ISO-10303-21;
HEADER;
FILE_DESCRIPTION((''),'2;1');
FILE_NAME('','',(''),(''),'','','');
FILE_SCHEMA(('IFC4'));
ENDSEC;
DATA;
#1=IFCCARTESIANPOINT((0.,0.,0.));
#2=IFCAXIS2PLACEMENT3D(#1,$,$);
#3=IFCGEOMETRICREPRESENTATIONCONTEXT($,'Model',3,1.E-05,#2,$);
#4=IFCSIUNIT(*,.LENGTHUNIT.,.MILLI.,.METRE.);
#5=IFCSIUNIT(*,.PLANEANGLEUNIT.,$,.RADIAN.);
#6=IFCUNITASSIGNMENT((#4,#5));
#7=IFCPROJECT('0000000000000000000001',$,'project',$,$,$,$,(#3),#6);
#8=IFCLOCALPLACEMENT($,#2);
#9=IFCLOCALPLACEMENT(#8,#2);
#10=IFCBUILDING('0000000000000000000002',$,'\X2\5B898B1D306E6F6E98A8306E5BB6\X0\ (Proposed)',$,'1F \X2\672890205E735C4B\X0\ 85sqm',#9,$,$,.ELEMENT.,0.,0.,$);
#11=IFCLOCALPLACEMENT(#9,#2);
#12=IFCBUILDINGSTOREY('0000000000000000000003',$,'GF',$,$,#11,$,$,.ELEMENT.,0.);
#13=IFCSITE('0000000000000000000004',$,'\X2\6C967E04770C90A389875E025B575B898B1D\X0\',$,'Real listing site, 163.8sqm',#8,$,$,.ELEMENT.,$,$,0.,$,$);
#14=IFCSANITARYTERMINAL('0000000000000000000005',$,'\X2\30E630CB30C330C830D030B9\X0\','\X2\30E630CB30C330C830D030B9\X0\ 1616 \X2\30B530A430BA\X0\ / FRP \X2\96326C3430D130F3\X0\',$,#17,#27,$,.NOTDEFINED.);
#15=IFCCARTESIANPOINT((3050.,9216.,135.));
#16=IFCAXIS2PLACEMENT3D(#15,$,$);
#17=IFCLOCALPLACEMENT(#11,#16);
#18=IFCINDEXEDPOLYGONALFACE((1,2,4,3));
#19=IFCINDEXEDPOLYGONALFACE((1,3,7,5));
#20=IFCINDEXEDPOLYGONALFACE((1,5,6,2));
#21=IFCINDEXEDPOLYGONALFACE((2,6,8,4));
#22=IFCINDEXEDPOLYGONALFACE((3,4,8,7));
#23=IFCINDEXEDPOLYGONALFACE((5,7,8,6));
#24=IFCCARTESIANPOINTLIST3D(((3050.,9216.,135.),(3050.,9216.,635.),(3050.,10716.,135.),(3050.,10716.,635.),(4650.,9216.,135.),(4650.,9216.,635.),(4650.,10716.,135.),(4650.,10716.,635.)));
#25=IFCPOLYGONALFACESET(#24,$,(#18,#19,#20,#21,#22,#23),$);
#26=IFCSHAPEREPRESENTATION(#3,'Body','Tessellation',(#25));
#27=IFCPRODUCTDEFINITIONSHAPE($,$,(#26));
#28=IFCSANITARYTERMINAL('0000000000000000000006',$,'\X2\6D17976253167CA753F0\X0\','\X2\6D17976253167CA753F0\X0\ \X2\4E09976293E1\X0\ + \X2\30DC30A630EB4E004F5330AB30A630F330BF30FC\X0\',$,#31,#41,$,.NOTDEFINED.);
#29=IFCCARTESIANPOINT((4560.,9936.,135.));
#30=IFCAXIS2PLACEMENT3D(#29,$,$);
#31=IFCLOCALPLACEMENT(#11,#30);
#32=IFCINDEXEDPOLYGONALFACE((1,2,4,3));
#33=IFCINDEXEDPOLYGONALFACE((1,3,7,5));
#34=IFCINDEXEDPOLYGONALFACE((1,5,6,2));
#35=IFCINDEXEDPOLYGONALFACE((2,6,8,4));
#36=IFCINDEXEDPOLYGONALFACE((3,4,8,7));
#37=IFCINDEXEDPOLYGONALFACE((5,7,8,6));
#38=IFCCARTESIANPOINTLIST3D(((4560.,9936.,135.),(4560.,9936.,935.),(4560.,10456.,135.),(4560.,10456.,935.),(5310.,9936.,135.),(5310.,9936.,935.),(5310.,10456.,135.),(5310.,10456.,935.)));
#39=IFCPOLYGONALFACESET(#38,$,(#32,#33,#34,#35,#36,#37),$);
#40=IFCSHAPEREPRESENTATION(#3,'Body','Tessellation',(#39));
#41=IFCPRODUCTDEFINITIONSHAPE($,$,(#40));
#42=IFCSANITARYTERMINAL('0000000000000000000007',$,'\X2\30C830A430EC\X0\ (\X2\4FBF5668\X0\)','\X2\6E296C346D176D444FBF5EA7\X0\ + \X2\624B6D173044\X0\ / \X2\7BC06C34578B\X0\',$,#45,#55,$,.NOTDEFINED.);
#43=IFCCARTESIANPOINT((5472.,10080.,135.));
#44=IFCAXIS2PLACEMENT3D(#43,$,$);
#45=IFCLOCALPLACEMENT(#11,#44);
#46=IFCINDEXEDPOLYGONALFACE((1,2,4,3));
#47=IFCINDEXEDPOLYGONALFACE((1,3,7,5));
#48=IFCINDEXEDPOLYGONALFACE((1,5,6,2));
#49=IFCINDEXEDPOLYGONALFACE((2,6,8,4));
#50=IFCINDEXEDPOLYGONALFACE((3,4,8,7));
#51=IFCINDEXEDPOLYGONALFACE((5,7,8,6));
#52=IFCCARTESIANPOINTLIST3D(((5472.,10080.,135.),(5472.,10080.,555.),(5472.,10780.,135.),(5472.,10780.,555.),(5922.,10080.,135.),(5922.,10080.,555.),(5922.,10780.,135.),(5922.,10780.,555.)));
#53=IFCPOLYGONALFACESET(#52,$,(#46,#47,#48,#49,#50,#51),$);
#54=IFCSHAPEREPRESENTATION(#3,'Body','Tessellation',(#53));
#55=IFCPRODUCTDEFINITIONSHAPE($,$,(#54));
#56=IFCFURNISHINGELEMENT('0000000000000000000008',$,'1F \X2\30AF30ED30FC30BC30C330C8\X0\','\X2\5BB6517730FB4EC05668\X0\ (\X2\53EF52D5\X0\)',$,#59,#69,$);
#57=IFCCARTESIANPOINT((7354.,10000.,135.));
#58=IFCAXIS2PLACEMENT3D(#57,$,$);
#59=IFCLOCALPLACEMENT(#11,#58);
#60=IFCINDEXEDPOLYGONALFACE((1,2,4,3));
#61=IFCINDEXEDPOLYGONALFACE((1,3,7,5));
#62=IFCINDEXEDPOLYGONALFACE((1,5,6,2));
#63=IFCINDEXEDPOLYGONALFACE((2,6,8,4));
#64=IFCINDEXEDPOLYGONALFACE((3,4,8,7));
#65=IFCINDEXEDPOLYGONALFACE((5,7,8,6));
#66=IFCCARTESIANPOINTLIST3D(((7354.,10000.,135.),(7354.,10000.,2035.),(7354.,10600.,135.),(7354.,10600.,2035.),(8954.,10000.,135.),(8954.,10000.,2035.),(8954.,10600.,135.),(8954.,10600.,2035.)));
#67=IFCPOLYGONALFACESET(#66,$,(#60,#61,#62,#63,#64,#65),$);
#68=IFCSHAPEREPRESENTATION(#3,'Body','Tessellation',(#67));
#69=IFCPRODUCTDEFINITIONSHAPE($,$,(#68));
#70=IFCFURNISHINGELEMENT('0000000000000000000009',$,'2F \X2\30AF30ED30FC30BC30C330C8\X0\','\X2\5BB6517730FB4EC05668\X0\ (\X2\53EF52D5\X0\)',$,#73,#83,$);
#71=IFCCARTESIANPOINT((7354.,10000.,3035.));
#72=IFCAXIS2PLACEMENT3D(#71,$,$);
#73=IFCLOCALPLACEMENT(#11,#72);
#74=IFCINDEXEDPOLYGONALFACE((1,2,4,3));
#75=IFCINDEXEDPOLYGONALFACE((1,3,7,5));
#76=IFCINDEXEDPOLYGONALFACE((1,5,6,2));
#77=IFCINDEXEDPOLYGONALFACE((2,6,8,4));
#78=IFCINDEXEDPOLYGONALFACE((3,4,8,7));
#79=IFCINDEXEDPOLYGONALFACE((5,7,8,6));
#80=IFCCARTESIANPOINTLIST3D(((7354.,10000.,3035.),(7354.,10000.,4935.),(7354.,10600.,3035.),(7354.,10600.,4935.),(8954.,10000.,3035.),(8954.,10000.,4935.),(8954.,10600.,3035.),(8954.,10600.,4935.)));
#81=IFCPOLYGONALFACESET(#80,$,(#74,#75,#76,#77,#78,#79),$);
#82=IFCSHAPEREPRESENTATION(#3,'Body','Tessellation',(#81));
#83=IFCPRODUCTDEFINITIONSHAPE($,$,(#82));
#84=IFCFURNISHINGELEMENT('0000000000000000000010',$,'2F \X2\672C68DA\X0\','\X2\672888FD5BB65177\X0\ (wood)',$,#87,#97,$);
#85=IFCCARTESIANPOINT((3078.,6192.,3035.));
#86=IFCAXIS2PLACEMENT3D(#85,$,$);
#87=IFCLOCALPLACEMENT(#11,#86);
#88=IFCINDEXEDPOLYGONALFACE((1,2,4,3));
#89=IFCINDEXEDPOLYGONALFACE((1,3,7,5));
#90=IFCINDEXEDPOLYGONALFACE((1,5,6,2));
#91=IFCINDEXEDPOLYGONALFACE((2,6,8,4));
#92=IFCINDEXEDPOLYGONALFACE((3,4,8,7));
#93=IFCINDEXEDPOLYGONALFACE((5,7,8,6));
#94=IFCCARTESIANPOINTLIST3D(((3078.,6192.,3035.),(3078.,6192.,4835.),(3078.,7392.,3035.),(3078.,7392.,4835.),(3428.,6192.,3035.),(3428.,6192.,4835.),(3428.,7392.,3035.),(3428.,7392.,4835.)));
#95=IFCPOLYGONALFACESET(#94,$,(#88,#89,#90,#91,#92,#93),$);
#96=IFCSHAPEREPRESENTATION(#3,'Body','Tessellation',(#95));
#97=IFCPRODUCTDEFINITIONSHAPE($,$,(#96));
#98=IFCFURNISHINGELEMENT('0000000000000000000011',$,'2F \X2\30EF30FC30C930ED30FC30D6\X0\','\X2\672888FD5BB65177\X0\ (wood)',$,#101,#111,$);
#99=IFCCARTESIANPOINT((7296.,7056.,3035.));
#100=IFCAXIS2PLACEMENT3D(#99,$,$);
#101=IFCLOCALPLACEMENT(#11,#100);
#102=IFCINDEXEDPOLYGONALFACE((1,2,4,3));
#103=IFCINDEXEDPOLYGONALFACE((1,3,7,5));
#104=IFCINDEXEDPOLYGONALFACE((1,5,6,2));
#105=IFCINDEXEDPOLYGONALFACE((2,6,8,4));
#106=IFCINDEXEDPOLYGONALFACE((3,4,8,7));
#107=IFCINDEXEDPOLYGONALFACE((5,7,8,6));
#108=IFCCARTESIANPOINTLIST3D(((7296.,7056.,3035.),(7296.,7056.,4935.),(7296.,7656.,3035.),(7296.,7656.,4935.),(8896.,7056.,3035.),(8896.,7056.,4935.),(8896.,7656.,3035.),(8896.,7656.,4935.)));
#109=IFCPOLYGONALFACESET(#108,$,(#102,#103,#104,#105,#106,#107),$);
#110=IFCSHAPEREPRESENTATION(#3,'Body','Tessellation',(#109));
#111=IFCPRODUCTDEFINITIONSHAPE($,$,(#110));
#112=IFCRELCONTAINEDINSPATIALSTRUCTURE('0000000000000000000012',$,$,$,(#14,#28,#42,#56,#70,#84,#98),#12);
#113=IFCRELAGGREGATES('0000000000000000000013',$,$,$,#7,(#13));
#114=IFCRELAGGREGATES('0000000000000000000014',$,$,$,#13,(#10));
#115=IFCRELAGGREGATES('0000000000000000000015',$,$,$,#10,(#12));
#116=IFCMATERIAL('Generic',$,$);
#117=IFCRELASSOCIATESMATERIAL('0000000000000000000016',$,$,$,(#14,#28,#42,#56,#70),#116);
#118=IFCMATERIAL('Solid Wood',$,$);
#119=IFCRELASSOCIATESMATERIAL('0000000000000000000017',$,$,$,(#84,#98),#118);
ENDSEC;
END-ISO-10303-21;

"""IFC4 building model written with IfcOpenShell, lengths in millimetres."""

from ifc_helpers import new_model, si_unit, frame, frame_2d, origin, place, context, project, spatial, rectangle, extrude, material, element, save


model = new_model("IFC4")

# Units and contexts
model_context = context("Model", 3, precision=1e-05, world=origin())
ifc_project = project(units=[si_unit("LENGTHUNIT", "METRE", prefix="MILLI"), si_unit("PLANEANGLEUNIT", "RADIAN")], contexts=[model_context])

# Site, building, storey
site_placement = place(None, origin())
site = spatial("IfcSite", under=ifc_project, at=site_placement, Name="沖縄県那覇市字安謝", ObjectType="Real listing site, 163.8sqm", CompositionType="ELEMENT", RefElevation=0.0)
building_placement = place(site_placement, origin())
building = spatial("IfcBuilding", under=site, at=building_placement, Name="安謝の潮風の家 (Proposed)", ObjectType="1F 木造平屋 85sqm", CompositionType="ELEMENT", ElevationOfRefHeight=0.0, ElevationOfTerrain=0.0)
storey_placement = place(building_placement, origin())
storey = spatial("IfcBuildingStorey", under=building, at=storey_placement, Name="GF", CompositionType="ELEMENT", Elevation=0.0)

# Shared definitions
ifc_material_1 = material(Name="Solid Wood")

# Shared definitions
ifc_material_2 = material(Name="Generic")

# Sanitary terminals
sanitary_terminal_1_placement = place(storey_placement, frame((3050.0, 9216.0, 135.0)))
element("IfcSanitaryTerminal", 1, at=sanitary_terminal_1_placement, inside=storey, material=ifc_material_2, Name="ユニットバス", Description="ユニットバス 1616 サイズ / FRP 防水パン", PredefinedType="NOTDEFINED", context=model_context, shape_type="SweptSolid", body=[
    extrude(rectangle(XDim=1600.0, YDim=1500.0, at=frame_2d((800.0, 750.0))), frame((3050.0, 9216.0, 135.0)), (0.0, 0.0, 1.0), 500.0),
])
sanitary_terminal_2_placement = place(storey_placement, frame((4560.0, 9936.0, 135.0)))
element("IfcSanitaryTerminal", 2, at=sanitary_terminal_2_placement, inside=storey, material=ifc_material_2, Name="洗面化粧台", Description="洗面化粧台 三面鏡 + ボウル一体カウンター", PredefinedType="NOTDEFINED", context=model_context, shape_type="SweptSolid", body=[
    extrude(rectangle(XDim=750.0, YDim=520.0, at=frame_2d((375.0, 260.0))), frame((4560.0, 9936.0, 135.0)), (0.0, 0.0, 1.0), 800.0),
])
sanitary_terminal_3_placement = place(storey_placement, frame((5472.0, 10080.0, 135.0)))
element("IfcSanitaryTerminal", 3, at=sanitary_terminal_3_placement, inside=storey, material=ifc_material_2, Name="トイレ (便器)", Description="温水洗浄便座 + 手洗い / 節水型", PredefinedType="NOTDEFINED", context=model_context, shape_type="SweptSolid", body=[
    extrude(rectangle(XDim=450.0, YDim=700.0, at=frame_2d((225.0, 350.0))), frame((5472.0, 10080.0, 135.0)), (0.0, 0.0, 1.0), 420.0),
])

# Furnishing elements
furnishing_1_placement = place(storey_placement, frame((7354.0, 10000.0, 135.0)))
element("IfcFurnishingElement", 4, at=furnishing_1_placement, inside=storey, material=ifc_material_2, Name="1F クローゼット", Description="家具・什器 (可動)", context=model_context, shape_type="SweptSolid", body=[
    extrude(rectangle(XDim=1600.0, YDim=600.0, at=frame_2d((800.0, 300.0))), frame((7354.0, 10000.0, 135.0)), (0.0, 0.0, 1.0), 1900.0),
])
furnishing_2_placement = place(storey_placement, frame((7354.0, 10000.0, 3035.0)))
element("IfcFurnishingElement", 5, at=furnishing_2_placement, inside=storey, material=ifc_material_2, Name="2F クローゼット", Description="家具・什器 (可動)", context=model_context, shape_type="SweptSolid", body=[
    extrude(rectangle(XDim=1600.0, YDim=600.0, at=frame_2d((800.0, 300.0))), frame((7354.0, 10000.0, 3035.0)), (0.0, 0.0, 1.0), 1900.0),
])
furnishing_3_placement = place(storey_placement, frame((3078.0, 6192.0, 3035.0)))
element("IfcFurnishingElement", 6, at=furnishing_3_placement, inside=storey, material=ifc_material_1, Name="2F 本棚", Description="木製家具 (wood)", context=model_context, shape_type="SweptSolid", body=[
    extrude(rectangle(XDim=350.0, YDim=1200.0, at=frame_2d((175.0, 600.0))), frame((3078.0, 6192.0, 3035.0)), (0.0, 0.0, 1.0), 1800.0),
])
furnishing_4_placement = place(storey_placement, frame((7296.0, 7056.0, 3035.0)))
element("IfcFurnishingElement", 7, at=furnishing_4_placement, inside=storey, material=ifc_material_1, Name="2F ワードローブ", Description="木製家具 (wood)", context=model_context, shape_type="SweptSolid", body=[
    extrude(rectangle(XDim=1600.0, YDim=600.0, at=frame_2d((800.0, 300.0))), frame((7296.0, 7056.0, 3035.0)), (0.0, 0.0, 1.0), 1900.0),
])

save(model, "model.ifc")
